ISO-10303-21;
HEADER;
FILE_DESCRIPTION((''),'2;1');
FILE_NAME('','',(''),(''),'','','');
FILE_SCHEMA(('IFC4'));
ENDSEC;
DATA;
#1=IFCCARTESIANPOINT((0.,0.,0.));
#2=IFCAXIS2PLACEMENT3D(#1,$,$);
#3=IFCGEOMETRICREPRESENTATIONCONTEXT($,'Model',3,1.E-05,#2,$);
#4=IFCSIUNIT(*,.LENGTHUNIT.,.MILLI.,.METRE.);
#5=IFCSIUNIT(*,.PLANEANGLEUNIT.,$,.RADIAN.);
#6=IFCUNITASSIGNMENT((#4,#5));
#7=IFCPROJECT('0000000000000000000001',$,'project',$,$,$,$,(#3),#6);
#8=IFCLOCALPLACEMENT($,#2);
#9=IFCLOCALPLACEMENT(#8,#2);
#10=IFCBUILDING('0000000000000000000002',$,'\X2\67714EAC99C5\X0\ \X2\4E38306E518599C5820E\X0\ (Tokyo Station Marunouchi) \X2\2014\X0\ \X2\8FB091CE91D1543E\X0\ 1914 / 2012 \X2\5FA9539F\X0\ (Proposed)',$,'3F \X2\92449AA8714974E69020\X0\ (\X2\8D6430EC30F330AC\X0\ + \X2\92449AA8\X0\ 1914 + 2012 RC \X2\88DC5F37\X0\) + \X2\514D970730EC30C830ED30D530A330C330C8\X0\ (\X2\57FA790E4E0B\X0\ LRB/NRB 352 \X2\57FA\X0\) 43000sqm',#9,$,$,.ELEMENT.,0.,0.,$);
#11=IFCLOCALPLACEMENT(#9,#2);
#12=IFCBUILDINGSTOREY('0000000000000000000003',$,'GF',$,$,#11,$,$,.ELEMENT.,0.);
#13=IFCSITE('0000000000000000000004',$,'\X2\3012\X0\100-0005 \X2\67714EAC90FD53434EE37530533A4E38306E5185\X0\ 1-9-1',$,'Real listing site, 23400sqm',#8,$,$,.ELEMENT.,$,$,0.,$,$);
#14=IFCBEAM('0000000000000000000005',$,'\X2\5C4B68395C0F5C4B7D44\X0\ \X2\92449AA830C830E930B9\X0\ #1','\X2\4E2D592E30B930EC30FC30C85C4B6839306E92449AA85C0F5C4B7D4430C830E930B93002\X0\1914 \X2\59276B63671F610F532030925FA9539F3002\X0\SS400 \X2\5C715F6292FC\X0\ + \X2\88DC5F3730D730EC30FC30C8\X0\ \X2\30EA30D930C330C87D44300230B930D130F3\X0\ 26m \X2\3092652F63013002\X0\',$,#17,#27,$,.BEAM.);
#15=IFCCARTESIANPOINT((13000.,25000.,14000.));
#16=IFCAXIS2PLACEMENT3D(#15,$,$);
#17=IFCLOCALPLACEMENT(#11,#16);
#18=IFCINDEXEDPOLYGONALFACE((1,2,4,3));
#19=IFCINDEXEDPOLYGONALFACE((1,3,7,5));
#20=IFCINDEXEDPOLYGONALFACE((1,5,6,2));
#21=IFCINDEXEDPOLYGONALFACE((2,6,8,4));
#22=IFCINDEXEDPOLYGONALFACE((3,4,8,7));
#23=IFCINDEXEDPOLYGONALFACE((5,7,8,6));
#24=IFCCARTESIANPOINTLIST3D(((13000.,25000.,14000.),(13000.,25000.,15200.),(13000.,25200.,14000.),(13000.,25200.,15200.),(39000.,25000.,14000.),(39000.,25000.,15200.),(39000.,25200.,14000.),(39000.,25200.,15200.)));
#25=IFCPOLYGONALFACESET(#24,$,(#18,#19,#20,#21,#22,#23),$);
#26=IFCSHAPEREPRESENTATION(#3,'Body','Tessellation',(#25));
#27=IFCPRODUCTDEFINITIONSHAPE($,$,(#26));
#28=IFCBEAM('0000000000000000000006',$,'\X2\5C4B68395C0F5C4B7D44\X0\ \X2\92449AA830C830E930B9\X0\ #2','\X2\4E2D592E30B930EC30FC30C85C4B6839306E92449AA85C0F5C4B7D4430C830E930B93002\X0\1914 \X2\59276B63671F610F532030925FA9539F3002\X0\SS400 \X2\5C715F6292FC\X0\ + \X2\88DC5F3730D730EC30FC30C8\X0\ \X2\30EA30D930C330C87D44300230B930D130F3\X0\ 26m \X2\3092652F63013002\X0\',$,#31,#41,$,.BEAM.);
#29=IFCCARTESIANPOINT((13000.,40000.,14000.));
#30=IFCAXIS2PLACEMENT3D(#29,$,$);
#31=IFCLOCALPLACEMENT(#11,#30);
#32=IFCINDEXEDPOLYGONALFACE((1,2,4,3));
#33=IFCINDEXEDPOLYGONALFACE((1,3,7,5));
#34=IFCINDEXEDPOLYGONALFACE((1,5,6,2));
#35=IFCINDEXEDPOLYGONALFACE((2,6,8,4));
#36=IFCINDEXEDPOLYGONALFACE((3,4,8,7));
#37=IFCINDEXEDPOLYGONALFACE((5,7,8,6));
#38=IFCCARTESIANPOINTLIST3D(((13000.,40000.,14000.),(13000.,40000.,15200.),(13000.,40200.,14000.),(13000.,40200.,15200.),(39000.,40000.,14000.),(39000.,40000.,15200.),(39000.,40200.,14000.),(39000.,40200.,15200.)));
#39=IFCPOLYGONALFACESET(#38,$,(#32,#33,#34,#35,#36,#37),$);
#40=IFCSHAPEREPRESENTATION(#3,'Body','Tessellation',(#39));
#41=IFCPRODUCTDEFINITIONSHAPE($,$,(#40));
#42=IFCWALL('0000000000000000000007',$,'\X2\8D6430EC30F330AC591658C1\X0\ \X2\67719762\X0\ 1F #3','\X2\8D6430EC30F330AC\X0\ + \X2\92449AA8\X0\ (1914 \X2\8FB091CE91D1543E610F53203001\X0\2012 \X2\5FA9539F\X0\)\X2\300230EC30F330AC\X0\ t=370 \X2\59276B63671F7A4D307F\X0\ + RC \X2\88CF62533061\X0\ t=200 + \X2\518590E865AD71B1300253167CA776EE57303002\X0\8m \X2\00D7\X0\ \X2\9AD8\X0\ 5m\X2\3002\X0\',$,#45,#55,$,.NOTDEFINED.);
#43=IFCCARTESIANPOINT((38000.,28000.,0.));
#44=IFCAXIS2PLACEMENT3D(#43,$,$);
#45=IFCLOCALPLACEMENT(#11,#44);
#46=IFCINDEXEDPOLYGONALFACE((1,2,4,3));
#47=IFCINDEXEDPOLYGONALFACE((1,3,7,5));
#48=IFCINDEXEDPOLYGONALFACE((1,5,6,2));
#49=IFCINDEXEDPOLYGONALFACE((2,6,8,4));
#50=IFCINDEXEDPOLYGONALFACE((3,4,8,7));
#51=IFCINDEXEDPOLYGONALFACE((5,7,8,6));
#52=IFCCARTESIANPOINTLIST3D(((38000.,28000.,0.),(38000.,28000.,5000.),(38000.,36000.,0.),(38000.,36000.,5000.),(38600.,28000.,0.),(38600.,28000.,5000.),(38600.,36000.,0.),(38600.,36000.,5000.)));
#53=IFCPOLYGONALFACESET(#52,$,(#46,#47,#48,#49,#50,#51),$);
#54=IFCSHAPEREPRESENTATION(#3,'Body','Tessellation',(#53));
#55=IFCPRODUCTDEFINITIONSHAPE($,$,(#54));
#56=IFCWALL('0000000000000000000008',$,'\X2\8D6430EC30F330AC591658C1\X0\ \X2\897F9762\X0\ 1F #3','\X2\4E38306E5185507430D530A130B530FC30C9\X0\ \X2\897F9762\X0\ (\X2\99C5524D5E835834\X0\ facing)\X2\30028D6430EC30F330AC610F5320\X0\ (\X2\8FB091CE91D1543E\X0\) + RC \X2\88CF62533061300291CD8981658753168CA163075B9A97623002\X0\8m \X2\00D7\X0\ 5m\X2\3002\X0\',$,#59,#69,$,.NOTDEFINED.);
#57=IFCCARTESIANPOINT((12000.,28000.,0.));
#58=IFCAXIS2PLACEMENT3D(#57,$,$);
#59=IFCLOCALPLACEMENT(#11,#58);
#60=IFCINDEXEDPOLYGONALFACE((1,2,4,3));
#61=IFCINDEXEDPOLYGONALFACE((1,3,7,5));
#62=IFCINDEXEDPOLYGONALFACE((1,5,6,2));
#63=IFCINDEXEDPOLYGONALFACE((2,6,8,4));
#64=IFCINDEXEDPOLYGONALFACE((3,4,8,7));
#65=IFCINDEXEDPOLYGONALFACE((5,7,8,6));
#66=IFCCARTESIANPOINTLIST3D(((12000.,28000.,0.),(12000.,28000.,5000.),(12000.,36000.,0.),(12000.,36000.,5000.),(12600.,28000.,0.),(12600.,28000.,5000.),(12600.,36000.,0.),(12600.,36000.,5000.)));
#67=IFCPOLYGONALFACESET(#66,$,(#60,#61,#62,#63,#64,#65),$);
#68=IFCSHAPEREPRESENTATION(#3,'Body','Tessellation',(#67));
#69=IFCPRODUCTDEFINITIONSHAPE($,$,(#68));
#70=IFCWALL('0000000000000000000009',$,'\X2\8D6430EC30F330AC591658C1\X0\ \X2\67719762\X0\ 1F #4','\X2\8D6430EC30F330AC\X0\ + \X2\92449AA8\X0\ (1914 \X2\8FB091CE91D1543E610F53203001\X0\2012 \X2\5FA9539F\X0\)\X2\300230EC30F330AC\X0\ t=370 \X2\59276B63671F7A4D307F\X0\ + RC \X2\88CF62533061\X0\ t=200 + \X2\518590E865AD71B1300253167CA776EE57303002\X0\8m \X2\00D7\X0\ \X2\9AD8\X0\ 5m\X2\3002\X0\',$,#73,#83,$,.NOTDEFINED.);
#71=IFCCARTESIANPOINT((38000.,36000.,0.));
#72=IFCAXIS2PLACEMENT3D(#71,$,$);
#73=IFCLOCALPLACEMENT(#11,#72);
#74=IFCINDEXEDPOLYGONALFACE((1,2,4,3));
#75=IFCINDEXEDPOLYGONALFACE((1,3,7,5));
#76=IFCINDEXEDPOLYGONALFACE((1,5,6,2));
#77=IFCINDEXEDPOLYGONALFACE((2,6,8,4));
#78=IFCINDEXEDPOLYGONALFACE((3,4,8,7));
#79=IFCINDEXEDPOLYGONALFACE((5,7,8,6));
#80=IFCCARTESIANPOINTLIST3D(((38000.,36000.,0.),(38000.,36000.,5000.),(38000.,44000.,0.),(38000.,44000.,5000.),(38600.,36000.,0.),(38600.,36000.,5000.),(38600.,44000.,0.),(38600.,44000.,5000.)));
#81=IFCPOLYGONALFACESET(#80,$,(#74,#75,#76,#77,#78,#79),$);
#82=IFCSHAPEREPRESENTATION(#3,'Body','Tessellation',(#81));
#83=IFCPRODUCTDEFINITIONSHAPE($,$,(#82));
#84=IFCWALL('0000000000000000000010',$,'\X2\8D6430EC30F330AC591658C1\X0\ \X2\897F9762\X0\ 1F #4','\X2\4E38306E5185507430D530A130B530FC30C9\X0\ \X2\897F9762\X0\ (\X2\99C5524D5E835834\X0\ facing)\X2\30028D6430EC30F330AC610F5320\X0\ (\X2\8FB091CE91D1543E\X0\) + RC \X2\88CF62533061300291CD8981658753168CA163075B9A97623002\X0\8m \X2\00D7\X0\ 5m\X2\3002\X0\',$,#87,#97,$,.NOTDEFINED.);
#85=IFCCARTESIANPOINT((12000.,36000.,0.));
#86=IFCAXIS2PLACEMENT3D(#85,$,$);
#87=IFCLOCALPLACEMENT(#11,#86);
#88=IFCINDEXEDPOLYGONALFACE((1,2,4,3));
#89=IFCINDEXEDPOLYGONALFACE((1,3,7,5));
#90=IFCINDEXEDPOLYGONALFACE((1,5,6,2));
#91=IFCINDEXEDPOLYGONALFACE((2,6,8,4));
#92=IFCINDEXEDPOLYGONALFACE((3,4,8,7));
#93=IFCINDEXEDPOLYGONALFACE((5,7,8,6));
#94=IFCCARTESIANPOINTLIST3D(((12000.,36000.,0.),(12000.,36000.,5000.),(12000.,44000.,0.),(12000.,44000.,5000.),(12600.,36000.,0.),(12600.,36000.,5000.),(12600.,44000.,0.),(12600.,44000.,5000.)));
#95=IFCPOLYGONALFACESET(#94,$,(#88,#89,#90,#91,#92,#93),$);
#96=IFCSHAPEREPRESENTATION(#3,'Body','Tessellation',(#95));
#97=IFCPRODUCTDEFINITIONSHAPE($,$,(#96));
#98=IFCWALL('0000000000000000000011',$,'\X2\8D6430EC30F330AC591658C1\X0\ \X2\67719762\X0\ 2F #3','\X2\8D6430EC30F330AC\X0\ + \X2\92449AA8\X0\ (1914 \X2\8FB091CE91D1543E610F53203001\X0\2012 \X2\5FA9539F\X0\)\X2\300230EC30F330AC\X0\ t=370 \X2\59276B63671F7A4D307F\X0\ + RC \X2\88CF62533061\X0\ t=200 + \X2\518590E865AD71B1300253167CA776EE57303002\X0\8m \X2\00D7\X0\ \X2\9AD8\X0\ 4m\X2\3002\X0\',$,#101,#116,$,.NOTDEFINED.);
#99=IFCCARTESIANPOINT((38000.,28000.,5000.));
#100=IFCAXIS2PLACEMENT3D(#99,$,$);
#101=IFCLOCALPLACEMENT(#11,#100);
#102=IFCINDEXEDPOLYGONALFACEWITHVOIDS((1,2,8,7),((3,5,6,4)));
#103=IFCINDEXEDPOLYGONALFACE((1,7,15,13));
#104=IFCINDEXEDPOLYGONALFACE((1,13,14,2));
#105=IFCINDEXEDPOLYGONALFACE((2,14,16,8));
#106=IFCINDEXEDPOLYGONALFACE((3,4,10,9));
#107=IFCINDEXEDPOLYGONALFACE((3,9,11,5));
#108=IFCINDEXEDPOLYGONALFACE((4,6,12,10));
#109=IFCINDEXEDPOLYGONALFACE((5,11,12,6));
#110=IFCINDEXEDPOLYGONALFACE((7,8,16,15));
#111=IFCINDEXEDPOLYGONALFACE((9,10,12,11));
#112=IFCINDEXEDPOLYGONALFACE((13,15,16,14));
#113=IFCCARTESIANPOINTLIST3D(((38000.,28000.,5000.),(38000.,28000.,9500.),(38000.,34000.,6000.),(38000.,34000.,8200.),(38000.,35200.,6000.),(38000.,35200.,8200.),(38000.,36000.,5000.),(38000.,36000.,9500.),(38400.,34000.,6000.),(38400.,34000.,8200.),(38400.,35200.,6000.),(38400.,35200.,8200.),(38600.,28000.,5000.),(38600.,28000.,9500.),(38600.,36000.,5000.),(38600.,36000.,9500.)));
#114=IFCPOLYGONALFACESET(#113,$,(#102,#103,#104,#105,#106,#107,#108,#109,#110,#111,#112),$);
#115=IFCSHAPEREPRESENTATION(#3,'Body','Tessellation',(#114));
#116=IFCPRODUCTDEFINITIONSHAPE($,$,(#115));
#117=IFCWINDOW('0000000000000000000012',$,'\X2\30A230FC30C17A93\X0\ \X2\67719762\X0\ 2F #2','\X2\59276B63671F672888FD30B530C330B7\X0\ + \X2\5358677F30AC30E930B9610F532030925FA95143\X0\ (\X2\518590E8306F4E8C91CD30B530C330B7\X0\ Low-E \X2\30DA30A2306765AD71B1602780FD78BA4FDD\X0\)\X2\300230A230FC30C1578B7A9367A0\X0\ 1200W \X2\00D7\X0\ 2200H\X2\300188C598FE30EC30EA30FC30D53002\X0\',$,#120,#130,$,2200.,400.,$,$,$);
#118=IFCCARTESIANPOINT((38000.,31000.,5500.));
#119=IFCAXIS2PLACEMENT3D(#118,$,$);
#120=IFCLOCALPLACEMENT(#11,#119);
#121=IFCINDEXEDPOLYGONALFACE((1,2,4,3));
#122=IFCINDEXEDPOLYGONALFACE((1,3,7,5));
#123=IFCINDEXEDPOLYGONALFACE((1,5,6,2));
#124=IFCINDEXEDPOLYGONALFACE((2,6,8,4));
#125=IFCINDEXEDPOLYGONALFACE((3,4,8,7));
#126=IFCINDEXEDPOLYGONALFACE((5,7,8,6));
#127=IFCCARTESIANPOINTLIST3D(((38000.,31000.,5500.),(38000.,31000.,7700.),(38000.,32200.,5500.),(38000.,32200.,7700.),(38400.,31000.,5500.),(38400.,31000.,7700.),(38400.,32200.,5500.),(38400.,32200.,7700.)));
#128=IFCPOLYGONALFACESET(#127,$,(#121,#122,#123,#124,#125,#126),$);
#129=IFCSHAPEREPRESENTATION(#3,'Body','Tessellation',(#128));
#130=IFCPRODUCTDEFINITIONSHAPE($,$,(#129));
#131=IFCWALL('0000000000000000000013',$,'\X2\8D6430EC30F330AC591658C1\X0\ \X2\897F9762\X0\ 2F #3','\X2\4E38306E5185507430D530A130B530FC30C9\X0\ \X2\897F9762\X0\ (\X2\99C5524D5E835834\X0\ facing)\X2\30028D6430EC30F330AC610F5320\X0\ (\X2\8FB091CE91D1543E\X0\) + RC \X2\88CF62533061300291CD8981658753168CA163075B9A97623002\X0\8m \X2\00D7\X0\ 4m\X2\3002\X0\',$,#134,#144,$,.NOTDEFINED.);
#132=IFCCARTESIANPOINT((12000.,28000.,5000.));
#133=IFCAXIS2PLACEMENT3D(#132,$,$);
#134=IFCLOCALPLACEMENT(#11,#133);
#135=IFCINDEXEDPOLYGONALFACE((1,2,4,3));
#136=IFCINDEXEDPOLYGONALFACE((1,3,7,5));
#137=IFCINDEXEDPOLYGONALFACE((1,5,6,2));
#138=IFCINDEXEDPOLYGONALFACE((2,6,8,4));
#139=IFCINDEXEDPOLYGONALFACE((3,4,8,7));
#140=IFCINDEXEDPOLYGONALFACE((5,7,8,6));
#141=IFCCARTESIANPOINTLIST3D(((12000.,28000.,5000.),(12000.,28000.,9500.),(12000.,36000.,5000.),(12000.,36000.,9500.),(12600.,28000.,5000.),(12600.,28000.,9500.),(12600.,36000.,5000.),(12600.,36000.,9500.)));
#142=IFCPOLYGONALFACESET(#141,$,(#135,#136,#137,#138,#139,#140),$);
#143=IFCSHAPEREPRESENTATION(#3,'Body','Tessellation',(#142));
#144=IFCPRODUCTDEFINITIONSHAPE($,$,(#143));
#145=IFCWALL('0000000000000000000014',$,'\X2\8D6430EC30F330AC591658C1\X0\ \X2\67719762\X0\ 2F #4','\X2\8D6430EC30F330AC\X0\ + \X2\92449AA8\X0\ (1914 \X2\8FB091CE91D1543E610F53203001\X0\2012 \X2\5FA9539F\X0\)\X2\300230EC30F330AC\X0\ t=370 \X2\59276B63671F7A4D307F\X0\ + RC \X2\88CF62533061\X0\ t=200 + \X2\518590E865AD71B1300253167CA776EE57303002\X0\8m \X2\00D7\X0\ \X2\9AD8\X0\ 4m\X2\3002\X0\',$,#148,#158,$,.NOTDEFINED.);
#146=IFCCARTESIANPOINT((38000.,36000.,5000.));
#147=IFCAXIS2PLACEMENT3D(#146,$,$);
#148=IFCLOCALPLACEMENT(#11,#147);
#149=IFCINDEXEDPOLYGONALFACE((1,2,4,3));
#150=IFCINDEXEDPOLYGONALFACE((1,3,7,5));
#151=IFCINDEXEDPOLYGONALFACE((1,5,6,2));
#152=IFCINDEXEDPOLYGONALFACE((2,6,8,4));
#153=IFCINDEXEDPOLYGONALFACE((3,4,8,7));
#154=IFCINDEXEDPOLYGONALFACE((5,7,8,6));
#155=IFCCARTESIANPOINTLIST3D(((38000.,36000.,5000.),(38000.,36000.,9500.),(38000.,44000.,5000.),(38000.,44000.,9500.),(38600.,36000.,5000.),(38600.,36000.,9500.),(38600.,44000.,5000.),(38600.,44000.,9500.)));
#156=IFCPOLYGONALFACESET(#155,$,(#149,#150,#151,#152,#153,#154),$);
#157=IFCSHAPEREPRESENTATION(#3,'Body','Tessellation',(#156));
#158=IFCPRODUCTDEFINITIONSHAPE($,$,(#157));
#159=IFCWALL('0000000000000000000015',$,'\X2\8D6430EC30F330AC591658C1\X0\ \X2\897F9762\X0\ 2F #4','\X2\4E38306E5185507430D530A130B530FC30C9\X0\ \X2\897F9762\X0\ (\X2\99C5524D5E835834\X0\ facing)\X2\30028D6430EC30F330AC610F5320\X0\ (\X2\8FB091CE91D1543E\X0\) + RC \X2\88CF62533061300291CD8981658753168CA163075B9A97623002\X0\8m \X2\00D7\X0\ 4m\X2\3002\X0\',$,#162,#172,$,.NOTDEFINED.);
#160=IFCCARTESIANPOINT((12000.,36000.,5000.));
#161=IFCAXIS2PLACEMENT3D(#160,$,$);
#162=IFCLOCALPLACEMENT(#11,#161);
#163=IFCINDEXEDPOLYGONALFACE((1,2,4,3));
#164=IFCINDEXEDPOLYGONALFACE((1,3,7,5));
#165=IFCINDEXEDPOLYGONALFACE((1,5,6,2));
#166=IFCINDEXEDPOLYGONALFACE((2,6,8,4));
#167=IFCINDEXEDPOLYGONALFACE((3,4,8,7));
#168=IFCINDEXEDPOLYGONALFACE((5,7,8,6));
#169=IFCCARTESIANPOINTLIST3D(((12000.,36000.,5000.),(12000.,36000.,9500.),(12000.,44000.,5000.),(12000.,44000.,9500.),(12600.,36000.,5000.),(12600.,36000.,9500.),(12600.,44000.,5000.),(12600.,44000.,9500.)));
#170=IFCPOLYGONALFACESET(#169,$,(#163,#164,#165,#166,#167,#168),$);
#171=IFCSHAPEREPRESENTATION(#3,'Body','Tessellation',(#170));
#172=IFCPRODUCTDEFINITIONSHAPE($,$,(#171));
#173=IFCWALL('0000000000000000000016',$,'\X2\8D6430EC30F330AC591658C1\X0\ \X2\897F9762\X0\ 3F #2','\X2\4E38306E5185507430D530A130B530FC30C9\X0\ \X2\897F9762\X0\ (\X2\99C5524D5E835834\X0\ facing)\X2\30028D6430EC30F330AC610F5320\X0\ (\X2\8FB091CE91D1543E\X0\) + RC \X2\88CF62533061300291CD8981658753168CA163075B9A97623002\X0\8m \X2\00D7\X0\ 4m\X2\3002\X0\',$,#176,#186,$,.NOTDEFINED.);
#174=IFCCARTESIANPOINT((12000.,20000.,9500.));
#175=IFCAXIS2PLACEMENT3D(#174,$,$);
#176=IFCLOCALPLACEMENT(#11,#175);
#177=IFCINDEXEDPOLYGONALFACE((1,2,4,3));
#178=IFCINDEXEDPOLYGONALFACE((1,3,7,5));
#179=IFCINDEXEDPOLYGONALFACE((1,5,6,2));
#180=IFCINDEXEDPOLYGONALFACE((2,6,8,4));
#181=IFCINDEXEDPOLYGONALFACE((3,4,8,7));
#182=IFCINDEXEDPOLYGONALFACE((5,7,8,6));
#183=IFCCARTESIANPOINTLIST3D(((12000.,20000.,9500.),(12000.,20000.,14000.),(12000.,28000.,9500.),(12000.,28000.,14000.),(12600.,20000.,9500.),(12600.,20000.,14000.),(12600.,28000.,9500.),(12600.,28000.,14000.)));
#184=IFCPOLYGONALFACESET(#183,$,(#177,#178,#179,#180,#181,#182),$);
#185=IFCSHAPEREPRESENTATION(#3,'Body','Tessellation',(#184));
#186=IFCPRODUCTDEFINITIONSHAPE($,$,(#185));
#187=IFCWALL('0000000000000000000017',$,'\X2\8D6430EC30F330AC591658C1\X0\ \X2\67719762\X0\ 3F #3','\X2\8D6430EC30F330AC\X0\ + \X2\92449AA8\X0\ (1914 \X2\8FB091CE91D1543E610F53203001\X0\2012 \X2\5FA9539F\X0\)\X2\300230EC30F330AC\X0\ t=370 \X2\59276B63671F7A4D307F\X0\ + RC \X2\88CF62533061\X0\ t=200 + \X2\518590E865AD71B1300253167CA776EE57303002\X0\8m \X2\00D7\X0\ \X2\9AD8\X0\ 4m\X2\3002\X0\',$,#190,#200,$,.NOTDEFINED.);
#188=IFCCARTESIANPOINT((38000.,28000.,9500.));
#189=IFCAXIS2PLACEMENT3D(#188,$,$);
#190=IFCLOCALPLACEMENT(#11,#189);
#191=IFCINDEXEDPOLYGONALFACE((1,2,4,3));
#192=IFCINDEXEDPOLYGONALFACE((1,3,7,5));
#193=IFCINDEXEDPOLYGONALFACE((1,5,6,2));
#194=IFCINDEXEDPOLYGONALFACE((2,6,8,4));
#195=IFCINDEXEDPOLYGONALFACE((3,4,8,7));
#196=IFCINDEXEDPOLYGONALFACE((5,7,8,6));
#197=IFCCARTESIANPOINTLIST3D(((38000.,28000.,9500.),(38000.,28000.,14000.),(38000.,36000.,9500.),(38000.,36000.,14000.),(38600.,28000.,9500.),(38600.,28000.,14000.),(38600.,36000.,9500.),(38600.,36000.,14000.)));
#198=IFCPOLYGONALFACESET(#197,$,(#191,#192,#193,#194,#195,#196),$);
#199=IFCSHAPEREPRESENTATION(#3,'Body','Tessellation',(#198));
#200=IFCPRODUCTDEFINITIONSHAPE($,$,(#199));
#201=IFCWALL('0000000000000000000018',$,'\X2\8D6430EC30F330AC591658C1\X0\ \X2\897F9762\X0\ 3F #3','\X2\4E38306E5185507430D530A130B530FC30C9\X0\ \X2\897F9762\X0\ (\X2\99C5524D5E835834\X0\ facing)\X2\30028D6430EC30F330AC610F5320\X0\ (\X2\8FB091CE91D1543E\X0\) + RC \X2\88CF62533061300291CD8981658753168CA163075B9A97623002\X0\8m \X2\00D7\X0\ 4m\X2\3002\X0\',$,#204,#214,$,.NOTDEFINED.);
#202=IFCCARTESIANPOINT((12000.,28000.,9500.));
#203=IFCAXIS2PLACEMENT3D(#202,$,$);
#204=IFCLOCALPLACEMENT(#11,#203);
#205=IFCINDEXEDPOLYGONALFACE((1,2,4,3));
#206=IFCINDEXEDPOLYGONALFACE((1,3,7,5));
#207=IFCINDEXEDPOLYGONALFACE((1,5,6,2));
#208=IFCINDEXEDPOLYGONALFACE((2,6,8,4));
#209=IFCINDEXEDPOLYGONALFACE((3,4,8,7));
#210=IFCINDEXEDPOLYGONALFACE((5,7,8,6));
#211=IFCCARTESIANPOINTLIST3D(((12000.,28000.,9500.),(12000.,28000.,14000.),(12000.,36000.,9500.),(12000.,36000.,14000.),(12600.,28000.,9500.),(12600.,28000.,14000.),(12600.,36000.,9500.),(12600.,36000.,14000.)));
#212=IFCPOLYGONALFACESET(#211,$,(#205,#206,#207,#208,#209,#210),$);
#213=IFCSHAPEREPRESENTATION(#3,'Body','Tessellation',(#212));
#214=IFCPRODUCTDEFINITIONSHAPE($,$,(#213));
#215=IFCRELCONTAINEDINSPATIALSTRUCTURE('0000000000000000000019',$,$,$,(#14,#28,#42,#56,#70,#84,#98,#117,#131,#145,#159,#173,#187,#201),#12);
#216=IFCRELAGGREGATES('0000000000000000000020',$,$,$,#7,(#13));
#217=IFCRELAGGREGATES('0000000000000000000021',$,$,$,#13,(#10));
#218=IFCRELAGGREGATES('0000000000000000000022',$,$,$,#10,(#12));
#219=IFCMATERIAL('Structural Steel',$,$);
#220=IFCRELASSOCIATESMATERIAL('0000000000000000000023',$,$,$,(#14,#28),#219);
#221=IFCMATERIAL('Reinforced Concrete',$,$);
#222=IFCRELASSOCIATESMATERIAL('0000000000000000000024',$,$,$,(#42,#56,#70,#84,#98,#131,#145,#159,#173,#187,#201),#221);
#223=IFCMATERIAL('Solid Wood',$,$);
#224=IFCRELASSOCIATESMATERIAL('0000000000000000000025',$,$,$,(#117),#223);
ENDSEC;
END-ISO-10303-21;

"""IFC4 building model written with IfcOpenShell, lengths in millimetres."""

from ifc_helpers import new_model, si_unit, frame, frame_2d, origin, place, context, project, spatial, rectangle, extrude, material, element, fill, save


model = new_model("IFC4")

# Units and contexts
model_context = context("Model", 3, precision=1e-05, world=origin())
ifc_project = project(units=[si_unit("LENGTHUNIT", "METRE", prefix="MILLI"), si_unit("PLANEANGLEUNIT", "RADIAN")], contexts=[model_context])

# Site, building, storey
site_placement = place(None, origin())
site = spatial("IfcSite", under=ifc_project, at=site_placement, Name="〒100-0005 東京都千代田区丸の内 1-9-1", ObjectType="Real listing site, 23400sqm", CompositionType="ELEMENT", RefElevation=0.0)
building_placement = place(site_placement, origin())
building = spatial("IfcBuilding", under=site, at=building_placement, Name="東京駅 丸の内駅舎 (Tokyo Station Marunouchi) — 辰野金吾 1914 / 2012 復原 (Proposed)", ObjectType="3F 鉄骨煉瓦造 (赤レンガ + 鉄骨 1914 + 2012 RC 補強) + 免震レトロフィット (基礎下 LRB/NRB 352 基) 43000sqm", CompositionType="ELEMENT", ElevationOfRefHeight=0.0, ElevationOfTerrain=0.0)
storey_placement = place(building_placement, origin())
storey = spatial("IfcBuildingStorey", under=building, at=storey_placement, Name="GF", CompositionType="ELEMENT", Elevation=0.0)

# Beams
ifc_material_1 = material(Name="Structural Steel")
beam_1_placement = place(storey_placement, frame((13000.0, 25000.0, 14000.0)))
element("IfcBeam", 1, at=beam_1_placement, inside=storey, material=ifc_material_1, Name="屋根小屋組 鉄骨トラス #1", Description="中央スレート屋根の鉄骨小屋組トラス。1914 大正期意匠を復原。SS400 山形鋼 + 補強プレート リベット組。スパン 26m を支持。", PredefinedType="BEAM", context=model_context, shape_type="SweptSolid", body=[
    extrude(rectangle(XDim=26000.0, YDim=200.0, at=frame_2d((13000.0, 100.0))), frame((13000.0, 25000.0, 14000.0)), (0.0, 0.0, 1.0), 1200.0),
])
beam_2_placement = place(storey_placement, frame((13000.0, 40000.0, 14000.0)))
element("IfcBeam", 2, at=beam_2_placement, inside=storey, material=ifc_material_1, Name="屋根小屋組 鉄骨トラス #2", Description="中央スレート屋根の鉄骨小屋組トラス。1914 大正期意匠を復原。SS400 山形鋼 + 補強プレート リベット組。スパン 26m を支持。", PredefinedType="BEAM", context=model_context, shape_type="SweptSolid", body=[
    extrude(rectangle(XDim=26000.0, YDim=200.0, at=frame_2d((13000.0, 100.0))), frame((13000.0, 40000.0, 14000.0)), (0.0, 0.0, 1.0), 1200.0),
])

# Walls
ifc_material_2 = material(Name="Reinforced Concrete")
wall_1_placement = place(storey_placement, frame((38000.0, 28000.0, 0.0)))
element("IfcWall", 3, at=wall_1_placement, inside=storey, material=ifc_material_2, Name="赤レンガ外壁 東面 1F #3", Description="赤レンガ + 鉄骨 (1914 辰野金吾意匠、2012 復原)。レンガ t=370 大正期積み + RC 裏打ち t=200 + 内部断熱。化粧目地。8m × 高 5m。", PredefinedType="NOTDEFINED", context=model_context, shape_type="SweptSolid", body=[
    extrude(rectangle(XDim=600.0, YDim=8000.0, at=frame_2d((300.0, 4000.0))), frame((38000.0, 28000.0, 0.0)), (0.0, 0.0, 1.0), 5000.0),
])
wall_2_placement = place(storey_placement, frame((12000.0, 28000.0, 0.0)))
element("IfcWall", 4, at=wall_2_placement, inside=storey, material=ifc_material_2, Name="赤レンガ外壁 西面 1F #3", Description="丸の内側ファサード 西面 (駅前広場 facing)。赤レンガ意匠 (辰野金吾) + RC 裏打ち。重要文化財指定面。8m × 5m。", PredefinedType="NOTDEFINED", context=model_context, shape_type="SweptSolid", body=[
    extrude(rectangle(XDim=600.0, YDim=8000.0, at=frame_2d((300.0, 4000.0))), frame((12000.0, 28000.0, 0.0)), (0.0, 0.0, 1.0), 5000.0),
])
wall_3_placement = place(storey_placement, frame((38000.0, 36000.0, 0.0)))
element("IfcWall", 5, at=wall_3_placement, inside=storey, material=ifc_material_2, Name="赤レンガ外壁 東面 1F #4", Description="赤レンガ + 鉄骨 (1914 辰野金吾意匠、2012 復原)。レンガ t=370 大正期積み + RC 裏打ち t=200 + 内部断熱。化粧目地。8m × 高 5m。", PredefinedType="NOTDEFINED", context=model_context, shape_type="SweptSolid", body=[
    extrude(rectangle(XDim=600.0, YDim=8000.0, at=frame_2d((300.0, 4000.0))), frame((38000.0, 36000.0, 0.0)), (0.0, 0.0, 1.0), 5000.0),
])
wall_4_placement = place(storey_placement, frame((12000.0, 36000.0, 0.0)))
element("IfcWall", 6, at=wall_4_placement, inside=storey, material=ifc_material_2, Name="赤レンガ外壁 西面 1F #4", Description="丸の内側ファサード 西面 (駅前広場 facing)。赤レンガ意匠 (辰野金吾) + RC 裏打ち。重要文化財指定面。8m × 5m。", PredefinedType="NOTDEFINED", context=model_context, shape_type="SweptSolid", body=[
    extrude(rectangle(XDim=600.0, YDim=8000.0, at=frame_2d((300.0, 4000.0))), frame((12000.0, 36000.0, 0.0)), (0.0, 0.0, 1.0), 5000.0),
])

# Wall, opening, window
wall_5_placement = place(storey_placement, frame((38000.0, 28000.0, 5000.0)))
wall_5 = element("IfcWall", 7, at=wall_5_placement, inside=storey, material=ifc_material_2, Name="赤レンガ外壁 東面 2F #3", Description="赤レンガ + 鉄骨 (1914 辰野金吾意匠、2012 復原)。レンガ t=370 大正期積み + RC 裏打ち t=200 + 内部断熱。化粧目地。8m × 高 4m。", PredefinedType="NOTDEFINED", context=model_context, shape_type="SweptSolid", body=[
    extrude(rectangle(XDim=600.0, YDim=8000.0, at=frame_2d((300.0, 4000.0))), frame((38000.0, 28000.0, 5000.0)), (0.0, 0.0, 1.0), 4500.0),
])
opening_1_placement = place(storey_placement, frame((38000.0, 31000.0, 5500.0)))
opening_1 = element("IfcOpeningElement", 8, at=opening_1_placement, cuts=wall_5, PredefinedType="NOTDEFINED", context=model_context, shape_type="SweptSolid", body=[
    extrude(rectangle(XDim=400.0, YDim=1200.0, at=frame_2d((200.0, 600.0))), frame((38000.0, 31000.0, 5500.0)), (0.0, 0.0, 1.0), 2200.0),
])
ifc_material_3 = material(Name="Solid Wood")
window_1_placement = place(storey_placement, frame((38000.0, 31000.0, 5500.0)))
window_1 = element("IfcWindow", 9, at=window_1_placement, inside=storey, material=ifc_material_3, Name="アーチ窓 東面 2F #2", Description="大正期木製サッシ + 単板ガラス意匠を復元 (内部は二重サッシ Low-E ペアで断熱性能確保)。アーチ型窓枠 1200W × 2200H、装飾レリーフ。", OverallHeight=2200.0, OverallWidth=400.0, context=model_context, shape_type="SweptSolid", body=[
    extrude(rectangle(XDim=400.0, YDim=1200.0, at=frame_2d((200.0, 600.0))), frame((38000.0, 31000.0, 5500.0)), (0.0, 0.0, 1.0), 2200.0),
])
fill(opening_1, window_1)

# Walls
wall_6_placement = place(storey_placement, frame((12000.0, 28000.0, 5000.0)))
element("IfcWall", 10, at=wall_6_placement, inside=storey, material=ifc_material_2, Name="赤レンガ外壁 西面 2F #3", Description="丸の内側ファサード 西面 (駅前広場 facing)。赤レンガ意匠 (辰野金吾) + RC 裏打ち。重要文化財指定面。8m × 4m。", PredefinedType="NOTDEFINED", context=model_context, shape_type="SweptSolid", body=[
    extrude(rectangle(XDim=600.0, YDim=8000.0, at=frame_2d((300.0, 4000.0))), frame((12000.0, 28000.0, 5000.0)), (0.0, 0.0, 1.0), 4500.0),
])
wall_7_placement = place(storey_placement, frame((38000.0, 36000.0, 5000.0)))
element("IfcWall", 11, at=wall_7_placement, inside=storey, material=ifc_material_2, Name="赤レンガ外壁 東面 2F #4", Description="赤レンガ + 鉄骨 (1914 辰野金吾意匠、2012 復原)。レンガ t=370 大正期積み + RC 裏打ち t=200 + 内部断熱。化粧目地。8m × 高 4m。", PredefinedType="NOTDEFINED", context=model_context, shape_type="SweptSolid", body=[
    extrude(rectangle(XDim=600.0, YDim=8000.0, at=frame_2d((300.0, 4000.0))), frame((38000.0, 36000.0, 5000.0)), (0.0, 0.0, 1.0), 4500.0),
])
wall_8_placement = place(storey_placement, frame((12000.0, 36000.0, 5000.0)))
element("IfcWall", 12, at=wall_8_placement, inside=storey, material=ifc_material_2, Name="赤レンガ外壁 西面 2F #4", Description="丸の内側ファサード 西面 (駅前広場 facing)。赤レンガ意匠 (辰野金吾) + RC 裏打ち。重要文化財指定面。8m × 4m。", PredefinedType="NOTDEFINED", context=model_context, shape_type="SweptSolid", body=[
    extrude(rectangle(XDim=600.0, YDim=8000.0, at=frame_2d((300.0, 4000.0))), frame((12000.0, 36000.0, 5000.0)), (0.0, 0.0, 1.0), 4500.0),
])
wall_9_placement = place(storey_placement, frame((12000.0, 20000.0, 9500.0)))
element("IfcWall", 13, at=wall_9_placement, inside=storey, material=ifc_material_2, Name="赤レンガ外壁 西面 3F #2", Description="丸の内側ファサード 西面 (駅前広場 facing)。赤レンガ意匠 (辰野金吾) + RC 裏打ち。重要文化財指定面。8m × 4m。", PredefinedType="NOTDEFINED", context=model_context, shape_type="SweptSolid", body=[
    extrude(rectangle(XDim=600.0, YDim=8000.0, at=frame_2d((300.0, 4000.0))), frame((12000.0, 20000.0, 9500.0)), (0.0, 0.0, 1.0), 4500.0),
])
wall_10_placement = place(storey_placement, frame((38000.0, 28000.0, 9500.0)))
element("IfcWall", 14, at=wall_10_placement, inside=storey, material=ifc_material_2, Name="赤レンガ外壁 東面 3F #3", Description="赤レンガ + 鉄骨 (1914 辰野金吾意匠、2012 復原)。レンガ t=370 大正期積み + RC 裏打ち t=200 + 内部断熱。化粧目地。8m × 高 4m。", PredefinedType="NOTDEFINED", context=model_context, shape_type="SweptSolid", body=[
    extrude(rectangle(XDim=600.0, YDim=8000.0, at=frame_2d((300.0, 4000.0))), frame((38000.0, 28000.0, 9500.0)), (0.0, 0.0, 1.0), 4500.0),
])
wall_11_placement = place(storey_placement, frame((12000.0, 28000.0, 9500.0)))
element("IfcWall", 15, at=wall_11_placement, inside=storey, material=ifc_material_2, Name="赤レンガ外壁 西面 3F #3", Description="丸の内側ファサード 西面 (駅前広場 facing)。赤レンガ意匠 (辰野金吾) + RC 裏打ち。重要文化財指定面。8m × 4m。", PredefinedType="NOTDEFINED", context=model_context, shape_type="SweptSolid", body=[
    extrude(rectangle(XDim=600.0, YDim=8000.0, at=frame_2d((300.0, 4000.0))), frame((12000.0, 28000.0, 9500.0)), (0.0, 0.0, 1.0), 4500.0),
])

save(model, "model.ifc")
